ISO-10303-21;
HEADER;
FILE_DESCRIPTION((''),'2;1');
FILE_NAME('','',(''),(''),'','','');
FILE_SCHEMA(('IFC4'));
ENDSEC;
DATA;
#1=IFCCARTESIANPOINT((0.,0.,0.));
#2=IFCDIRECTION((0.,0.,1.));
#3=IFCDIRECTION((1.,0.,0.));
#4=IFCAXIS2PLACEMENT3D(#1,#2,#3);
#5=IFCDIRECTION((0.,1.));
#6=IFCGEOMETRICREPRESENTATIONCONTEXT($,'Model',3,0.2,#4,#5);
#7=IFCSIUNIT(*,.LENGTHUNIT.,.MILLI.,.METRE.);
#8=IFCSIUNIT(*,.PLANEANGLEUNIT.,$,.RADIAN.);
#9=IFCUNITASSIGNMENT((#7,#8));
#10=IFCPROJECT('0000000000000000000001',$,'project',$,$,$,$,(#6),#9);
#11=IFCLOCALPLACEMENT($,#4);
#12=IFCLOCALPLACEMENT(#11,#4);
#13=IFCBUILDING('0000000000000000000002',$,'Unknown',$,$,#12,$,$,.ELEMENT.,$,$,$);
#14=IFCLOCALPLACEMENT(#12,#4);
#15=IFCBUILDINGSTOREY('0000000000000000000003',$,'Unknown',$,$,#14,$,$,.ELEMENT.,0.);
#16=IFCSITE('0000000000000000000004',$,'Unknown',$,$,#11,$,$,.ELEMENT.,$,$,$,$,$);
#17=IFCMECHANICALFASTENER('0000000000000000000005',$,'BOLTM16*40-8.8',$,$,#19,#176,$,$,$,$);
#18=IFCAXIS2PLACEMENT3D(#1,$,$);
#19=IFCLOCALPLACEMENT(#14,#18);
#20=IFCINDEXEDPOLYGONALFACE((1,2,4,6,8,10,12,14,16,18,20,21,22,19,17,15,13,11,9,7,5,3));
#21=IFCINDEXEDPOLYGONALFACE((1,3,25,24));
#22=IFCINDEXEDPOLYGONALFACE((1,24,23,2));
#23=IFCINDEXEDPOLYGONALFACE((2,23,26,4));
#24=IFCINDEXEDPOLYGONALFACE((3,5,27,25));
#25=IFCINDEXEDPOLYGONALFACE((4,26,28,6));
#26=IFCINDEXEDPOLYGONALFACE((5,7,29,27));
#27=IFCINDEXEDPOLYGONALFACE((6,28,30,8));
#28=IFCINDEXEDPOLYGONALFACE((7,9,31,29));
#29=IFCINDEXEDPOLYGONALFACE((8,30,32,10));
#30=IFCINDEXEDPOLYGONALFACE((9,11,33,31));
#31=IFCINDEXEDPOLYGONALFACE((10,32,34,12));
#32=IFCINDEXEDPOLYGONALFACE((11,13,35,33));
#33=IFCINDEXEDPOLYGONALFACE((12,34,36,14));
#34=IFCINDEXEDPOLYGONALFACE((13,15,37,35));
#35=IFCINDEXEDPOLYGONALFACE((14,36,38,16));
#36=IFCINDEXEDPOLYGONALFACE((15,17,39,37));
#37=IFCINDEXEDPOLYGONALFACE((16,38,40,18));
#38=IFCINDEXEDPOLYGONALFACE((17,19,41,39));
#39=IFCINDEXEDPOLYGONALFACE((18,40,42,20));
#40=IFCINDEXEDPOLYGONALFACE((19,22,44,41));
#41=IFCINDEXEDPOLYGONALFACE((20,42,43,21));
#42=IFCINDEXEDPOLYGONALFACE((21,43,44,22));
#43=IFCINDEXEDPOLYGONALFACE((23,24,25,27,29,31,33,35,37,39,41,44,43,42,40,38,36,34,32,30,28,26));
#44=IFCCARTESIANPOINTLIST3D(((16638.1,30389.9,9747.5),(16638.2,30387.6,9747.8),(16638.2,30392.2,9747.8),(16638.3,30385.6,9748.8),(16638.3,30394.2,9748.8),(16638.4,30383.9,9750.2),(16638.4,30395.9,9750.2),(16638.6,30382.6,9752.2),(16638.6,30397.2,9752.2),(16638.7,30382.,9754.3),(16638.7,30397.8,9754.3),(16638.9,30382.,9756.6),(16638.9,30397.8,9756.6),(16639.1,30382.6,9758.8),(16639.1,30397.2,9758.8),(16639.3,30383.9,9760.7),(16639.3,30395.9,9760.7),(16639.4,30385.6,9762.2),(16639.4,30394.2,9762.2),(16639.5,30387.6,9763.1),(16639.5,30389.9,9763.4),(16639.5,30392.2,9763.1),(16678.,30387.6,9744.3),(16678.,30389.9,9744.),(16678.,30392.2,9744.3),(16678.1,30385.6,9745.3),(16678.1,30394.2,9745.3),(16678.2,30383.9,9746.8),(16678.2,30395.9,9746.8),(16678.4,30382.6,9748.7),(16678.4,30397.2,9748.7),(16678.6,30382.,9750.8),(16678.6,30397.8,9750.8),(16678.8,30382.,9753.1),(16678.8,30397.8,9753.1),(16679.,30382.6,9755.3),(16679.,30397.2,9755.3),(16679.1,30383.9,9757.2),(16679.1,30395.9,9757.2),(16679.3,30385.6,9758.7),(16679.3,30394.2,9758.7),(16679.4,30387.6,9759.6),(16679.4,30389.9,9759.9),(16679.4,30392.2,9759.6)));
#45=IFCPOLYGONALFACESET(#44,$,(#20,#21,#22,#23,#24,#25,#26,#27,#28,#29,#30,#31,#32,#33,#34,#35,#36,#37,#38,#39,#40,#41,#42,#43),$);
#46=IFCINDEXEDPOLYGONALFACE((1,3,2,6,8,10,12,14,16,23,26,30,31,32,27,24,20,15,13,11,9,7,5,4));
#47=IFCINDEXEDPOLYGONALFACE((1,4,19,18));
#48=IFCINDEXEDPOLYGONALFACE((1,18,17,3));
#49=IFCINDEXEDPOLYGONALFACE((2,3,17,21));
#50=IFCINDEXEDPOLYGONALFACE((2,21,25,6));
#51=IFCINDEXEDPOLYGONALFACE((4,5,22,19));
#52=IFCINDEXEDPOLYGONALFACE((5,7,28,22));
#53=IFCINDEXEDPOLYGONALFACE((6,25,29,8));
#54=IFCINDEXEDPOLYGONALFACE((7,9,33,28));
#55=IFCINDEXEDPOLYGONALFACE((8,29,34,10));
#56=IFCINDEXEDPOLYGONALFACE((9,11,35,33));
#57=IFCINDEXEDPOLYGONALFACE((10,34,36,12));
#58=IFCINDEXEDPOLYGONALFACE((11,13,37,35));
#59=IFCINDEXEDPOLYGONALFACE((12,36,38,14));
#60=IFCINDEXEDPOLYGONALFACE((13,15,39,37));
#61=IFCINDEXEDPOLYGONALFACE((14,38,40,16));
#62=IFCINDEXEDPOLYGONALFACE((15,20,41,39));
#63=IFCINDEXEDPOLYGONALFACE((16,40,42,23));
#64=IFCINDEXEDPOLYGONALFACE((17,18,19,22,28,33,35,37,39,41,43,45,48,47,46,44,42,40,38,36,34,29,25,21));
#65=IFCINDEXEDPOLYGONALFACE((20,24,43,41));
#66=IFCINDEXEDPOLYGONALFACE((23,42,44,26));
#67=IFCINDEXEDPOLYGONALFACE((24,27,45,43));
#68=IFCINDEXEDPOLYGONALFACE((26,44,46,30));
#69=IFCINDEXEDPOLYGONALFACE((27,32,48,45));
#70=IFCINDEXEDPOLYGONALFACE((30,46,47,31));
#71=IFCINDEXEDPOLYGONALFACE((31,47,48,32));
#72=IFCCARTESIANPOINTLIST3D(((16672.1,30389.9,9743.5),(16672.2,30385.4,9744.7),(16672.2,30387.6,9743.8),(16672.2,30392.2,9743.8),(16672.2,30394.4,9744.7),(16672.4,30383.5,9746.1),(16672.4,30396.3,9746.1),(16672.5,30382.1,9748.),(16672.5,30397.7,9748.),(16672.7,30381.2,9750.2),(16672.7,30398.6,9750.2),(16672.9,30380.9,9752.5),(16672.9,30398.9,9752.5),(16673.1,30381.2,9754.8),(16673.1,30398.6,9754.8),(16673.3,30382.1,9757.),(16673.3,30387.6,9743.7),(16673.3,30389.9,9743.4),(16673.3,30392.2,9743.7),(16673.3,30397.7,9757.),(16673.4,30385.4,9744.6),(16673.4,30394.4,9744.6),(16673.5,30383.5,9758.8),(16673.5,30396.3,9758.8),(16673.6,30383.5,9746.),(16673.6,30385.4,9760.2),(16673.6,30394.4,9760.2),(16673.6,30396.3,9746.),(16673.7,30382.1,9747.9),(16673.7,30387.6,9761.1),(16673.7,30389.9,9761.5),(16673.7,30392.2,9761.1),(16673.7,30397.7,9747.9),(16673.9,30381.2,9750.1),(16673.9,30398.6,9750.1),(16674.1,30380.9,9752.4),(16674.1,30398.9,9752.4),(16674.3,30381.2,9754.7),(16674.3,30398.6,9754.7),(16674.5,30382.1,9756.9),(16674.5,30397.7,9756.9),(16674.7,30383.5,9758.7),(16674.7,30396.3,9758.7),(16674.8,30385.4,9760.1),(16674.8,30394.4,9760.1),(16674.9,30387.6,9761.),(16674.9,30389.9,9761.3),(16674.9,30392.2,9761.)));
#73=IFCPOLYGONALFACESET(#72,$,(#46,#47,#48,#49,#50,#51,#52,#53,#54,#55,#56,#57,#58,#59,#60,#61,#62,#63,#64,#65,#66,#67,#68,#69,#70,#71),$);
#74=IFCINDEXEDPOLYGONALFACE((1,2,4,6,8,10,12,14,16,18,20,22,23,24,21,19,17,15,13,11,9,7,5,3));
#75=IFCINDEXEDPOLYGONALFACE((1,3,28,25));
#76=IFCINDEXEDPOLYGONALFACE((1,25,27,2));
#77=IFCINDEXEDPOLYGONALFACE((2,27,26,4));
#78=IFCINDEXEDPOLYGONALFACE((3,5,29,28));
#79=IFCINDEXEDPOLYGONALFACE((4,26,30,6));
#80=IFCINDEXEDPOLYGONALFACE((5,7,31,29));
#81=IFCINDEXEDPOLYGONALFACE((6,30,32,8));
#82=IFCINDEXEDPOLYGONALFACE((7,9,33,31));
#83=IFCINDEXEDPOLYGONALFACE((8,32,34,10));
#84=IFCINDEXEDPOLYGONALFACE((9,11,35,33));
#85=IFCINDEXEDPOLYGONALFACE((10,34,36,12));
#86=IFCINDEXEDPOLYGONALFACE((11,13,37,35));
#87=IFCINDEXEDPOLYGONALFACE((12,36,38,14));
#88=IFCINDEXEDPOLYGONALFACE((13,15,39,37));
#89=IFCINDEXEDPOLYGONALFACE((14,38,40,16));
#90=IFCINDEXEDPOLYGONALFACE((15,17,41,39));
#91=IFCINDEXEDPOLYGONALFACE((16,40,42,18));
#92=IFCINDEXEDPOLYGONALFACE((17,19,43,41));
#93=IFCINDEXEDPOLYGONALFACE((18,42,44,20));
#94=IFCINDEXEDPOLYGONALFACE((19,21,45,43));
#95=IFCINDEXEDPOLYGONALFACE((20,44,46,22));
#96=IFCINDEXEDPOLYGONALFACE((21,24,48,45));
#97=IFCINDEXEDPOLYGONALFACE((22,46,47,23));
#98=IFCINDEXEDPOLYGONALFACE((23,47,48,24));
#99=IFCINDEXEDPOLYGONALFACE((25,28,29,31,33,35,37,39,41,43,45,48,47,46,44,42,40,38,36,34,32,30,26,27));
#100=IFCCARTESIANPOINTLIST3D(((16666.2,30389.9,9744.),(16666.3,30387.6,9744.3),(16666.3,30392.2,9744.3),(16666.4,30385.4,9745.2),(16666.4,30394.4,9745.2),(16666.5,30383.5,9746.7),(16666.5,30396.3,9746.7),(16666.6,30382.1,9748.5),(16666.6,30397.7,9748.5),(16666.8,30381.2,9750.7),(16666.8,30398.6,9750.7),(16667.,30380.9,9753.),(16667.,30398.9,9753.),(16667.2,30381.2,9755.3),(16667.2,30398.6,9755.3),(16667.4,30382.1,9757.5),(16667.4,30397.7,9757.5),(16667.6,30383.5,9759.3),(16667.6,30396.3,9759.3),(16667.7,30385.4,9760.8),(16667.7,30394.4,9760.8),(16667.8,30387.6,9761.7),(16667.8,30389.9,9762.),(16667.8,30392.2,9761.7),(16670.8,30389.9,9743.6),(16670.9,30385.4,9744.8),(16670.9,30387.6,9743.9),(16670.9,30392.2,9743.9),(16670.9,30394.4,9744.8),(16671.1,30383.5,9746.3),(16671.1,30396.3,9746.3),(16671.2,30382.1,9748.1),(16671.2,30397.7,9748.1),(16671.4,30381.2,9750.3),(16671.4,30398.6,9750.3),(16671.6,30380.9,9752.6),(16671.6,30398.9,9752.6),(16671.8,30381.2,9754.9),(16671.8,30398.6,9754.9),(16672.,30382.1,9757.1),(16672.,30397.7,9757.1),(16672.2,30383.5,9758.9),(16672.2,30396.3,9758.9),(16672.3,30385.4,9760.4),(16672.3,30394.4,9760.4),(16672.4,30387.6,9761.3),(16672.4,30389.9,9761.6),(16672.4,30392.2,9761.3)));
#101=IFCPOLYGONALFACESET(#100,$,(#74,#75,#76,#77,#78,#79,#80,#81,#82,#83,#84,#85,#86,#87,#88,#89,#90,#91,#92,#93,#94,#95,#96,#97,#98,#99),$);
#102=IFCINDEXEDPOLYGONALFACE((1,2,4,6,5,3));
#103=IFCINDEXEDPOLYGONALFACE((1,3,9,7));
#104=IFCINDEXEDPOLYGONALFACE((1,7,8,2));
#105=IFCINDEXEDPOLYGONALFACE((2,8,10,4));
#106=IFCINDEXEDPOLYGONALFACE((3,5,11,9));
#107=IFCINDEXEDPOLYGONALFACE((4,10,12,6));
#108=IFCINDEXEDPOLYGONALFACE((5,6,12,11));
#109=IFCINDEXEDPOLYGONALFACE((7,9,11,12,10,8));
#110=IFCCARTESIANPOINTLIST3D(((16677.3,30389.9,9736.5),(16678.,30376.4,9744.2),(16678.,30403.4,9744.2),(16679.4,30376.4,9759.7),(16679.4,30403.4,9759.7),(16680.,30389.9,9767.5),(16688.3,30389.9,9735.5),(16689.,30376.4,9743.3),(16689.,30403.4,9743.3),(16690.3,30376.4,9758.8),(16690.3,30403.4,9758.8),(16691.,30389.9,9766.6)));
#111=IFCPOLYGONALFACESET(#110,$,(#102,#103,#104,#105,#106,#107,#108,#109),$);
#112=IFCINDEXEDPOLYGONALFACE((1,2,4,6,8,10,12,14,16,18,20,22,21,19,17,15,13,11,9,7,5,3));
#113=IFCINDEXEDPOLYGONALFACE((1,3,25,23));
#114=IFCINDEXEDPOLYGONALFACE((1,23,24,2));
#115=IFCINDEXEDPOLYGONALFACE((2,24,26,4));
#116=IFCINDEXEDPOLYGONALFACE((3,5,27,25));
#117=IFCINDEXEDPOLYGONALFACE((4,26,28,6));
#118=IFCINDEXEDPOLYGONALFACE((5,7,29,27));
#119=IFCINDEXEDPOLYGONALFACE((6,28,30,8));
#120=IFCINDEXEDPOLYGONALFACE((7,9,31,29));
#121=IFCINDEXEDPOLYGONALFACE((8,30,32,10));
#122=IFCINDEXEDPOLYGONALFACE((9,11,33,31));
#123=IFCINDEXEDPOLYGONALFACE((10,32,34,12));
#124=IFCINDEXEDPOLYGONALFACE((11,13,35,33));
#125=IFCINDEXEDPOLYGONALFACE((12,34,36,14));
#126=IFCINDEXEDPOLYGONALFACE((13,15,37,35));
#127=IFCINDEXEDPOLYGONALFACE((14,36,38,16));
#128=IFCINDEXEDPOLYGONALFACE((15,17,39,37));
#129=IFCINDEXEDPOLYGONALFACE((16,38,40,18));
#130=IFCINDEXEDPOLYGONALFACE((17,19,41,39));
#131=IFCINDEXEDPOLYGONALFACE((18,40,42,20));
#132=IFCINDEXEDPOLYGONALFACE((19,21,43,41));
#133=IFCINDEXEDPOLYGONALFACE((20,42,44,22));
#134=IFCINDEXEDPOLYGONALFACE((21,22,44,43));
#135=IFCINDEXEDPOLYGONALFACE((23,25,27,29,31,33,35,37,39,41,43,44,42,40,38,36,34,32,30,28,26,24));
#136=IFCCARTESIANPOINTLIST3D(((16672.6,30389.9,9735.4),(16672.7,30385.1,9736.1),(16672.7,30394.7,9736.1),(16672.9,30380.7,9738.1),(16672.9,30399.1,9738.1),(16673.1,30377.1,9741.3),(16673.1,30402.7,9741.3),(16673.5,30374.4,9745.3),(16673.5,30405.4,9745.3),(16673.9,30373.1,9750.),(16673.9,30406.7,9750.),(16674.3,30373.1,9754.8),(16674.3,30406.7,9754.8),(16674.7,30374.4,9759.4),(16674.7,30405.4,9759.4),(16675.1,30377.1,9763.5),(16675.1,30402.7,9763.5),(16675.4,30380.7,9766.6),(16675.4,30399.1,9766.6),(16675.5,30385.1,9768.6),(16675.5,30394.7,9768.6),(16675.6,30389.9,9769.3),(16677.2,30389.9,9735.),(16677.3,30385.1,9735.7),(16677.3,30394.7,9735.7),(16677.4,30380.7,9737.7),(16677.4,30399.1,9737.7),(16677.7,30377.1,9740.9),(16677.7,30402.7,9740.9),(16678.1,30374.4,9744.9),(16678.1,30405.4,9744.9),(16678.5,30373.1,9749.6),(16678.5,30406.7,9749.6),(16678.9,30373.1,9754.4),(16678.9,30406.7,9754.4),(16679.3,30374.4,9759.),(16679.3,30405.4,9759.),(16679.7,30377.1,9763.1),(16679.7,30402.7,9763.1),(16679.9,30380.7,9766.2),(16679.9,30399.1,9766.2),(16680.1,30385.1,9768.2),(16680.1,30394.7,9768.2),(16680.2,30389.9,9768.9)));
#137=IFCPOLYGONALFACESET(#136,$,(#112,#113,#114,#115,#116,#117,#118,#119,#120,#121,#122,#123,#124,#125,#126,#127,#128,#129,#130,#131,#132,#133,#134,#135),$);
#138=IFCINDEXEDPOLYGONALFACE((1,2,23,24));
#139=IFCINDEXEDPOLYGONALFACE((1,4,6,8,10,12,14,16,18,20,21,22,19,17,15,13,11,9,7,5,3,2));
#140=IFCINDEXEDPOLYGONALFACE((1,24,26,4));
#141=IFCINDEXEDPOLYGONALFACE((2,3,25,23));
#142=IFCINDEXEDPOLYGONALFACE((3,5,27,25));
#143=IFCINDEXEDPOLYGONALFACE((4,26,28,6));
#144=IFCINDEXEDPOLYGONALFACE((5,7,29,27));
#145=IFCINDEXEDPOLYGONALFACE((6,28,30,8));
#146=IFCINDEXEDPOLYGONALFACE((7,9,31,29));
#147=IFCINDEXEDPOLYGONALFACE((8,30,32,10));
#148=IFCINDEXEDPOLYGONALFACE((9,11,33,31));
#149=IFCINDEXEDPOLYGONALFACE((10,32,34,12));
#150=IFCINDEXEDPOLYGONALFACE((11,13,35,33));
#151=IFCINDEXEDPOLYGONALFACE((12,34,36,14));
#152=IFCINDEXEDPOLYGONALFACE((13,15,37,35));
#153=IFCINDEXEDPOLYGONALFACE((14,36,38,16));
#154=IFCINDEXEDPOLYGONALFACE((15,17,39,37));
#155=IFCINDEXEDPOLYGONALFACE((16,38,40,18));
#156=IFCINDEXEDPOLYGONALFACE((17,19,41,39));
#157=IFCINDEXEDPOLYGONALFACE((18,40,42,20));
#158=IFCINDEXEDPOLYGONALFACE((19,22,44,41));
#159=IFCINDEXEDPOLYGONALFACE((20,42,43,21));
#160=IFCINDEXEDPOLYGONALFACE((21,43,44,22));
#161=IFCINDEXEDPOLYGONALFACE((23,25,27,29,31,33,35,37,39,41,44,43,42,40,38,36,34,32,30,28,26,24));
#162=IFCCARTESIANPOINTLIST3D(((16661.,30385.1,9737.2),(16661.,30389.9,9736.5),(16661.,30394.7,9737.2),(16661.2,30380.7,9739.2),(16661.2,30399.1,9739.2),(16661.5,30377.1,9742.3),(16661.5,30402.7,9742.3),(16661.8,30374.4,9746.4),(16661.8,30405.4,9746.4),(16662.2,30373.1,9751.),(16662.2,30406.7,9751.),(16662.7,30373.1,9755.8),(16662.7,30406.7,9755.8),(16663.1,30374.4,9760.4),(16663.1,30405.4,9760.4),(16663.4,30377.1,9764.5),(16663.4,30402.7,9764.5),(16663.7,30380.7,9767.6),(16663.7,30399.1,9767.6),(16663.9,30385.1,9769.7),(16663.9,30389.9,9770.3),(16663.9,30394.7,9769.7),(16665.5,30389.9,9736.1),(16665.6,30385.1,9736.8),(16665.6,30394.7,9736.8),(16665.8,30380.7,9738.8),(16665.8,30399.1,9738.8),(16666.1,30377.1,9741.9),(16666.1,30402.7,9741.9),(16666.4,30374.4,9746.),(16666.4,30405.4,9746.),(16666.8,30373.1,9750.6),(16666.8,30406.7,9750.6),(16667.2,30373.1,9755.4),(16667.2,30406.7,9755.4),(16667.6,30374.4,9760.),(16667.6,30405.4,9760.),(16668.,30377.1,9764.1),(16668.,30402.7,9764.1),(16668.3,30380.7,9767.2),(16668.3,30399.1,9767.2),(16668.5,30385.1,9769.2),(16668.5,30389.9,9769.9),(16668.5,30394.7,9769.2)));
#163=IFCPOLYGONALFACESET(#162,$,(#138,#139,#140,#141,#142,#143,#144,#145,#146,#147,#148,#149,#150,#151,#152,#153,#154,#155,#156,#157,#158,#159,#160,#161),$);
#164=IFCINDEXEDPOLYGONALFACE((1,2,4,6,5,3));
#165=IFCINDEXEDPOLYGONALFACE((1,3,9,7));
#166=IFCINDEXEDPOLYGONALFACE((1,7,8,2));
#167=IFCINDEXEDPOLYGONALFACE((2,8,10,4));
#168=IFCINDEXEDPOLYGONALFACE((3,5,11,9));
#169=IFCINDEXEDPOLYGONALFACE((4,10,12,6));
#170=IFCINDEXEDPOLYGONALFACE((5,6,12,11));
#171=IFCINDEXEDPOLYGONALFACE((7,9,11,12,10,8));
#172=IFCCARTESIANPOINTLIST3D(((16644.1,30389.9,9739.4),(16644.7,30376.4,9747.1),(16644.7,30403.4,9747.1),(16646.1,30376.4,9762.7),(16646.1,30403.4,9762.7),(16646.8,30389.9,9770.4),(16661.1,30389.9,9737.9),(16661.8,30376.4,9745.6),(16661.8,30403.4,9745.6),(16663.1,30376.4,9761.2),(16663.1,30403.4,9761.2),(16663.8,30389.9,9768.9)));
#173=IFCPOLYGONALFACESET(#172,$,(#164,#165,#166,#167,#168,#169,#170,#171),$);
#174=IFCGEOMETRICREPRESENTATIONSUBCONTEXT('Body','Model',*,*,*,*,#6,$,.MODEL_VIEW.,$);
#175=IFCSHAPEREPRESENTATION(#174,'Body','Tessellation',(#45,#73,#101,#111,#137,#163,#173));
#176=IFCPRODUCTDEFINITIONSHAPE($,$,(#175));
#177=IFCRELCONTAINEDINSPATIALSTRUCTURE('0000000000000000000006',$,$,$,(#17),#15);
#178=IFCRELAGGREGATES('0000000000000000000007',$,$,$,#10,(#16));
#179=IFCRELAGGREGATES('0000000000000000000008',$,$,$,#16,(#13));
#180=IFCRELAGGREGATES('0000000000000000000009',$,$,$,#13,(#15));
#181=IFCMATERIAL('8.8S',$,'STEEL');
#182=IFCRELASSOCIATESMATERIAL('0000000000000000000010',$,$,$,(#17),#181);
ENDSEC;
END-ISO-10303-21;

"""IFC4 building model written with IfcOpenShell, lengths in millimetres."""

from ifc_helpers import new_model, si_unit, direction, frame, origin_with_axes, place, context, subcontext, project, spatial, line, arc, indexed_curve, outline, extrude, source, transform, mapped, material, element, save


model = new_model("IFC4")

# Units and contexts
model_context = context("Model", 3, precision=0.2, world=origin_with_axes(), true_north=direction((0.0, 1.0)))
body_context = subcontext(model_context, "Body", "Model", "MODEL_VIEW")
ifc_project = project(units=[si_unit("LENGTHUNIT", "METRE", prefix="MILLI"), si_unit("PLANEANGLEUNIT", "RADIAN")], contexts=[model_context])

# Site, building, storey
site_placement = place(None, origin_with_axes())
site = spatial("IfcSite", under=ifc_project, at=site_placement, Name="Unknown", CompositionType="ELEMENT")
building_placement = place(site_placement, origin_with_axes())
building = spatial("IfcBuilding", under=site, at=building_placement, Name="Unknown", CompositionType="ELEMENT")
storey_placement = place(building_placement, origin_with_axes())
storey = spatial("IfcBuildingStorey", under=building, at=storey_placement, Name="Unknown", CompositionType="ELEMENT", Elevation=0.0)

# Mechanical fastener
ifc_material_1 = material(Name="8.8S", Category="STEEL")
shared_shape_1 = source(origin_with_axes(), body_context, "Body", "SweptSolid", [
    extrude(outline(indexed_curve([(8.0, 0.0), (0.0, 8.0), (-8.0, 0.0), (0.0, -8.0)], segments=[arc(1, 2, 3), arc(3, 4, 1)])), frame((0.0, 0.0, 7.1), z_axis=(0.0, 0.0, -1.0), x_axis=(0.0, 1.0, 0.0)), (0.0, 0.0, 1.0), 40.0),
    extrude(outline(indexed_curve([(0.0, 9.0), (6.4, 6.4), (9.0, 0.0), (6.4, -6.4), (0.0, -9.0), (-0.8, -9.0), (-9.0, 0.0), (-6.4, 6.4)], segments=[arc(1, 2, 3), arc(3, 4, 5), arc(5, 6, 7), arc(7, 8, 1)])), frame((0.0, 0.0, 2.5), z_axis=(0.0, 0.0, -1.0), x_axis=(0.0, 1.0, 0.0)), (0.0, 0.0, 1.0), 1.2),
    extrude(outline(indexed_curve([(0.0, 9.0), (6.4, 6.4), (9.0, 0.0), (6.4, -6.4), (0.0, -9.0), (-0.8, -9.0), (-9.0, 0.0), (-6.4, 6.4)], segments=[arc(1, 2, 3), arc(3, 4, 5), arc(5, 6, 7), arc(7, 8, 1)])), frame((0.0, 0.0, 0.0), z_axis=(0.0, 0.0, -1.0), x_axis=(0.0, 1.0, 0.0)), (0.0, 0.0, 1.0), 4.6),
    extrude(outline(indexed_curve([(15.6, 0.0), (7.8, 13.5), (-7.8, 13.5), (-15.6, 0.0), (-7.8, -13.5), (7.8, -13.5)], segments=[line(1, 2, 3, 4, 5, 6, 1)])), frame((0.0, 0.0, 18.1), z_axis=(0.0, 0.0, -1.0), x_axis=(0.0, 1.0, 0.0)), (0.0, 0.0, 1.0), 11.0),
    extrude(outline(indexed_curve([(17.0, 0.0), (0.0, 17.0), (-17.0, 0.0), (0.0, -17.0)], segments=[arc(1, 2, 3), arc(3, 4, 1)])), frame((0.0, 0.0, 7.1), z_axis=(0.0, 0.0, -1.0), x_axis=(0.0, 1.0, 0.0)), (0.0, 0.0, 1.0), 4.6),
    extrude(outline(indexed_curve([(17.0, 0.0), (0.0, 17.0), (-17.0, 0.0), (0.0, -17.0)], segments=[arc(1, 2, 3), arc(3, 4, 1)])), frame((0.0, 0.0, -4.6), z_axis=(0.0, 0.0, -1.0), x_axis=(0.0, 1.0, 0.0)), (0.0, 0.0, 1.0), 4.6),
    extrude(outline(indexed_curve([(15.6, 0.0), (7.8, 13.5), (-7.8, 13.5), (-15.6, 0.0), (-7.8, -13.5), (7.8, -13.5)], segments=[line(1, 2, 3, 4, 5, 6, 1)])), frame((0.0, 0.0, -9.2), z_axis=(0.0, 0.0, -1.0), x_axis=(0.0, 1.0, 0.0)), (0.0, 0.0, 1.0), 17.1),
])
mechanical_fastener_1_placement = place(storey_placement, frame((16671.6, 30389.9, 9752.6), z_axis=(0.996195, 0.0, -0.087156), x_axis=(0.0, 1.0, 0.0)))
element("IfcMechanicalFastener", 1, at=mechanical_fastener_1_placement, inside=storey, material=ifc_material_1, Name="BOLTM16*40-8.8", context=body_context, shape_type="MappedRepresentation", body=[
    mapped(shared_shape_1, transform((0.0, 0.0, 0.0))),
])

save(model, "model.ifc")
